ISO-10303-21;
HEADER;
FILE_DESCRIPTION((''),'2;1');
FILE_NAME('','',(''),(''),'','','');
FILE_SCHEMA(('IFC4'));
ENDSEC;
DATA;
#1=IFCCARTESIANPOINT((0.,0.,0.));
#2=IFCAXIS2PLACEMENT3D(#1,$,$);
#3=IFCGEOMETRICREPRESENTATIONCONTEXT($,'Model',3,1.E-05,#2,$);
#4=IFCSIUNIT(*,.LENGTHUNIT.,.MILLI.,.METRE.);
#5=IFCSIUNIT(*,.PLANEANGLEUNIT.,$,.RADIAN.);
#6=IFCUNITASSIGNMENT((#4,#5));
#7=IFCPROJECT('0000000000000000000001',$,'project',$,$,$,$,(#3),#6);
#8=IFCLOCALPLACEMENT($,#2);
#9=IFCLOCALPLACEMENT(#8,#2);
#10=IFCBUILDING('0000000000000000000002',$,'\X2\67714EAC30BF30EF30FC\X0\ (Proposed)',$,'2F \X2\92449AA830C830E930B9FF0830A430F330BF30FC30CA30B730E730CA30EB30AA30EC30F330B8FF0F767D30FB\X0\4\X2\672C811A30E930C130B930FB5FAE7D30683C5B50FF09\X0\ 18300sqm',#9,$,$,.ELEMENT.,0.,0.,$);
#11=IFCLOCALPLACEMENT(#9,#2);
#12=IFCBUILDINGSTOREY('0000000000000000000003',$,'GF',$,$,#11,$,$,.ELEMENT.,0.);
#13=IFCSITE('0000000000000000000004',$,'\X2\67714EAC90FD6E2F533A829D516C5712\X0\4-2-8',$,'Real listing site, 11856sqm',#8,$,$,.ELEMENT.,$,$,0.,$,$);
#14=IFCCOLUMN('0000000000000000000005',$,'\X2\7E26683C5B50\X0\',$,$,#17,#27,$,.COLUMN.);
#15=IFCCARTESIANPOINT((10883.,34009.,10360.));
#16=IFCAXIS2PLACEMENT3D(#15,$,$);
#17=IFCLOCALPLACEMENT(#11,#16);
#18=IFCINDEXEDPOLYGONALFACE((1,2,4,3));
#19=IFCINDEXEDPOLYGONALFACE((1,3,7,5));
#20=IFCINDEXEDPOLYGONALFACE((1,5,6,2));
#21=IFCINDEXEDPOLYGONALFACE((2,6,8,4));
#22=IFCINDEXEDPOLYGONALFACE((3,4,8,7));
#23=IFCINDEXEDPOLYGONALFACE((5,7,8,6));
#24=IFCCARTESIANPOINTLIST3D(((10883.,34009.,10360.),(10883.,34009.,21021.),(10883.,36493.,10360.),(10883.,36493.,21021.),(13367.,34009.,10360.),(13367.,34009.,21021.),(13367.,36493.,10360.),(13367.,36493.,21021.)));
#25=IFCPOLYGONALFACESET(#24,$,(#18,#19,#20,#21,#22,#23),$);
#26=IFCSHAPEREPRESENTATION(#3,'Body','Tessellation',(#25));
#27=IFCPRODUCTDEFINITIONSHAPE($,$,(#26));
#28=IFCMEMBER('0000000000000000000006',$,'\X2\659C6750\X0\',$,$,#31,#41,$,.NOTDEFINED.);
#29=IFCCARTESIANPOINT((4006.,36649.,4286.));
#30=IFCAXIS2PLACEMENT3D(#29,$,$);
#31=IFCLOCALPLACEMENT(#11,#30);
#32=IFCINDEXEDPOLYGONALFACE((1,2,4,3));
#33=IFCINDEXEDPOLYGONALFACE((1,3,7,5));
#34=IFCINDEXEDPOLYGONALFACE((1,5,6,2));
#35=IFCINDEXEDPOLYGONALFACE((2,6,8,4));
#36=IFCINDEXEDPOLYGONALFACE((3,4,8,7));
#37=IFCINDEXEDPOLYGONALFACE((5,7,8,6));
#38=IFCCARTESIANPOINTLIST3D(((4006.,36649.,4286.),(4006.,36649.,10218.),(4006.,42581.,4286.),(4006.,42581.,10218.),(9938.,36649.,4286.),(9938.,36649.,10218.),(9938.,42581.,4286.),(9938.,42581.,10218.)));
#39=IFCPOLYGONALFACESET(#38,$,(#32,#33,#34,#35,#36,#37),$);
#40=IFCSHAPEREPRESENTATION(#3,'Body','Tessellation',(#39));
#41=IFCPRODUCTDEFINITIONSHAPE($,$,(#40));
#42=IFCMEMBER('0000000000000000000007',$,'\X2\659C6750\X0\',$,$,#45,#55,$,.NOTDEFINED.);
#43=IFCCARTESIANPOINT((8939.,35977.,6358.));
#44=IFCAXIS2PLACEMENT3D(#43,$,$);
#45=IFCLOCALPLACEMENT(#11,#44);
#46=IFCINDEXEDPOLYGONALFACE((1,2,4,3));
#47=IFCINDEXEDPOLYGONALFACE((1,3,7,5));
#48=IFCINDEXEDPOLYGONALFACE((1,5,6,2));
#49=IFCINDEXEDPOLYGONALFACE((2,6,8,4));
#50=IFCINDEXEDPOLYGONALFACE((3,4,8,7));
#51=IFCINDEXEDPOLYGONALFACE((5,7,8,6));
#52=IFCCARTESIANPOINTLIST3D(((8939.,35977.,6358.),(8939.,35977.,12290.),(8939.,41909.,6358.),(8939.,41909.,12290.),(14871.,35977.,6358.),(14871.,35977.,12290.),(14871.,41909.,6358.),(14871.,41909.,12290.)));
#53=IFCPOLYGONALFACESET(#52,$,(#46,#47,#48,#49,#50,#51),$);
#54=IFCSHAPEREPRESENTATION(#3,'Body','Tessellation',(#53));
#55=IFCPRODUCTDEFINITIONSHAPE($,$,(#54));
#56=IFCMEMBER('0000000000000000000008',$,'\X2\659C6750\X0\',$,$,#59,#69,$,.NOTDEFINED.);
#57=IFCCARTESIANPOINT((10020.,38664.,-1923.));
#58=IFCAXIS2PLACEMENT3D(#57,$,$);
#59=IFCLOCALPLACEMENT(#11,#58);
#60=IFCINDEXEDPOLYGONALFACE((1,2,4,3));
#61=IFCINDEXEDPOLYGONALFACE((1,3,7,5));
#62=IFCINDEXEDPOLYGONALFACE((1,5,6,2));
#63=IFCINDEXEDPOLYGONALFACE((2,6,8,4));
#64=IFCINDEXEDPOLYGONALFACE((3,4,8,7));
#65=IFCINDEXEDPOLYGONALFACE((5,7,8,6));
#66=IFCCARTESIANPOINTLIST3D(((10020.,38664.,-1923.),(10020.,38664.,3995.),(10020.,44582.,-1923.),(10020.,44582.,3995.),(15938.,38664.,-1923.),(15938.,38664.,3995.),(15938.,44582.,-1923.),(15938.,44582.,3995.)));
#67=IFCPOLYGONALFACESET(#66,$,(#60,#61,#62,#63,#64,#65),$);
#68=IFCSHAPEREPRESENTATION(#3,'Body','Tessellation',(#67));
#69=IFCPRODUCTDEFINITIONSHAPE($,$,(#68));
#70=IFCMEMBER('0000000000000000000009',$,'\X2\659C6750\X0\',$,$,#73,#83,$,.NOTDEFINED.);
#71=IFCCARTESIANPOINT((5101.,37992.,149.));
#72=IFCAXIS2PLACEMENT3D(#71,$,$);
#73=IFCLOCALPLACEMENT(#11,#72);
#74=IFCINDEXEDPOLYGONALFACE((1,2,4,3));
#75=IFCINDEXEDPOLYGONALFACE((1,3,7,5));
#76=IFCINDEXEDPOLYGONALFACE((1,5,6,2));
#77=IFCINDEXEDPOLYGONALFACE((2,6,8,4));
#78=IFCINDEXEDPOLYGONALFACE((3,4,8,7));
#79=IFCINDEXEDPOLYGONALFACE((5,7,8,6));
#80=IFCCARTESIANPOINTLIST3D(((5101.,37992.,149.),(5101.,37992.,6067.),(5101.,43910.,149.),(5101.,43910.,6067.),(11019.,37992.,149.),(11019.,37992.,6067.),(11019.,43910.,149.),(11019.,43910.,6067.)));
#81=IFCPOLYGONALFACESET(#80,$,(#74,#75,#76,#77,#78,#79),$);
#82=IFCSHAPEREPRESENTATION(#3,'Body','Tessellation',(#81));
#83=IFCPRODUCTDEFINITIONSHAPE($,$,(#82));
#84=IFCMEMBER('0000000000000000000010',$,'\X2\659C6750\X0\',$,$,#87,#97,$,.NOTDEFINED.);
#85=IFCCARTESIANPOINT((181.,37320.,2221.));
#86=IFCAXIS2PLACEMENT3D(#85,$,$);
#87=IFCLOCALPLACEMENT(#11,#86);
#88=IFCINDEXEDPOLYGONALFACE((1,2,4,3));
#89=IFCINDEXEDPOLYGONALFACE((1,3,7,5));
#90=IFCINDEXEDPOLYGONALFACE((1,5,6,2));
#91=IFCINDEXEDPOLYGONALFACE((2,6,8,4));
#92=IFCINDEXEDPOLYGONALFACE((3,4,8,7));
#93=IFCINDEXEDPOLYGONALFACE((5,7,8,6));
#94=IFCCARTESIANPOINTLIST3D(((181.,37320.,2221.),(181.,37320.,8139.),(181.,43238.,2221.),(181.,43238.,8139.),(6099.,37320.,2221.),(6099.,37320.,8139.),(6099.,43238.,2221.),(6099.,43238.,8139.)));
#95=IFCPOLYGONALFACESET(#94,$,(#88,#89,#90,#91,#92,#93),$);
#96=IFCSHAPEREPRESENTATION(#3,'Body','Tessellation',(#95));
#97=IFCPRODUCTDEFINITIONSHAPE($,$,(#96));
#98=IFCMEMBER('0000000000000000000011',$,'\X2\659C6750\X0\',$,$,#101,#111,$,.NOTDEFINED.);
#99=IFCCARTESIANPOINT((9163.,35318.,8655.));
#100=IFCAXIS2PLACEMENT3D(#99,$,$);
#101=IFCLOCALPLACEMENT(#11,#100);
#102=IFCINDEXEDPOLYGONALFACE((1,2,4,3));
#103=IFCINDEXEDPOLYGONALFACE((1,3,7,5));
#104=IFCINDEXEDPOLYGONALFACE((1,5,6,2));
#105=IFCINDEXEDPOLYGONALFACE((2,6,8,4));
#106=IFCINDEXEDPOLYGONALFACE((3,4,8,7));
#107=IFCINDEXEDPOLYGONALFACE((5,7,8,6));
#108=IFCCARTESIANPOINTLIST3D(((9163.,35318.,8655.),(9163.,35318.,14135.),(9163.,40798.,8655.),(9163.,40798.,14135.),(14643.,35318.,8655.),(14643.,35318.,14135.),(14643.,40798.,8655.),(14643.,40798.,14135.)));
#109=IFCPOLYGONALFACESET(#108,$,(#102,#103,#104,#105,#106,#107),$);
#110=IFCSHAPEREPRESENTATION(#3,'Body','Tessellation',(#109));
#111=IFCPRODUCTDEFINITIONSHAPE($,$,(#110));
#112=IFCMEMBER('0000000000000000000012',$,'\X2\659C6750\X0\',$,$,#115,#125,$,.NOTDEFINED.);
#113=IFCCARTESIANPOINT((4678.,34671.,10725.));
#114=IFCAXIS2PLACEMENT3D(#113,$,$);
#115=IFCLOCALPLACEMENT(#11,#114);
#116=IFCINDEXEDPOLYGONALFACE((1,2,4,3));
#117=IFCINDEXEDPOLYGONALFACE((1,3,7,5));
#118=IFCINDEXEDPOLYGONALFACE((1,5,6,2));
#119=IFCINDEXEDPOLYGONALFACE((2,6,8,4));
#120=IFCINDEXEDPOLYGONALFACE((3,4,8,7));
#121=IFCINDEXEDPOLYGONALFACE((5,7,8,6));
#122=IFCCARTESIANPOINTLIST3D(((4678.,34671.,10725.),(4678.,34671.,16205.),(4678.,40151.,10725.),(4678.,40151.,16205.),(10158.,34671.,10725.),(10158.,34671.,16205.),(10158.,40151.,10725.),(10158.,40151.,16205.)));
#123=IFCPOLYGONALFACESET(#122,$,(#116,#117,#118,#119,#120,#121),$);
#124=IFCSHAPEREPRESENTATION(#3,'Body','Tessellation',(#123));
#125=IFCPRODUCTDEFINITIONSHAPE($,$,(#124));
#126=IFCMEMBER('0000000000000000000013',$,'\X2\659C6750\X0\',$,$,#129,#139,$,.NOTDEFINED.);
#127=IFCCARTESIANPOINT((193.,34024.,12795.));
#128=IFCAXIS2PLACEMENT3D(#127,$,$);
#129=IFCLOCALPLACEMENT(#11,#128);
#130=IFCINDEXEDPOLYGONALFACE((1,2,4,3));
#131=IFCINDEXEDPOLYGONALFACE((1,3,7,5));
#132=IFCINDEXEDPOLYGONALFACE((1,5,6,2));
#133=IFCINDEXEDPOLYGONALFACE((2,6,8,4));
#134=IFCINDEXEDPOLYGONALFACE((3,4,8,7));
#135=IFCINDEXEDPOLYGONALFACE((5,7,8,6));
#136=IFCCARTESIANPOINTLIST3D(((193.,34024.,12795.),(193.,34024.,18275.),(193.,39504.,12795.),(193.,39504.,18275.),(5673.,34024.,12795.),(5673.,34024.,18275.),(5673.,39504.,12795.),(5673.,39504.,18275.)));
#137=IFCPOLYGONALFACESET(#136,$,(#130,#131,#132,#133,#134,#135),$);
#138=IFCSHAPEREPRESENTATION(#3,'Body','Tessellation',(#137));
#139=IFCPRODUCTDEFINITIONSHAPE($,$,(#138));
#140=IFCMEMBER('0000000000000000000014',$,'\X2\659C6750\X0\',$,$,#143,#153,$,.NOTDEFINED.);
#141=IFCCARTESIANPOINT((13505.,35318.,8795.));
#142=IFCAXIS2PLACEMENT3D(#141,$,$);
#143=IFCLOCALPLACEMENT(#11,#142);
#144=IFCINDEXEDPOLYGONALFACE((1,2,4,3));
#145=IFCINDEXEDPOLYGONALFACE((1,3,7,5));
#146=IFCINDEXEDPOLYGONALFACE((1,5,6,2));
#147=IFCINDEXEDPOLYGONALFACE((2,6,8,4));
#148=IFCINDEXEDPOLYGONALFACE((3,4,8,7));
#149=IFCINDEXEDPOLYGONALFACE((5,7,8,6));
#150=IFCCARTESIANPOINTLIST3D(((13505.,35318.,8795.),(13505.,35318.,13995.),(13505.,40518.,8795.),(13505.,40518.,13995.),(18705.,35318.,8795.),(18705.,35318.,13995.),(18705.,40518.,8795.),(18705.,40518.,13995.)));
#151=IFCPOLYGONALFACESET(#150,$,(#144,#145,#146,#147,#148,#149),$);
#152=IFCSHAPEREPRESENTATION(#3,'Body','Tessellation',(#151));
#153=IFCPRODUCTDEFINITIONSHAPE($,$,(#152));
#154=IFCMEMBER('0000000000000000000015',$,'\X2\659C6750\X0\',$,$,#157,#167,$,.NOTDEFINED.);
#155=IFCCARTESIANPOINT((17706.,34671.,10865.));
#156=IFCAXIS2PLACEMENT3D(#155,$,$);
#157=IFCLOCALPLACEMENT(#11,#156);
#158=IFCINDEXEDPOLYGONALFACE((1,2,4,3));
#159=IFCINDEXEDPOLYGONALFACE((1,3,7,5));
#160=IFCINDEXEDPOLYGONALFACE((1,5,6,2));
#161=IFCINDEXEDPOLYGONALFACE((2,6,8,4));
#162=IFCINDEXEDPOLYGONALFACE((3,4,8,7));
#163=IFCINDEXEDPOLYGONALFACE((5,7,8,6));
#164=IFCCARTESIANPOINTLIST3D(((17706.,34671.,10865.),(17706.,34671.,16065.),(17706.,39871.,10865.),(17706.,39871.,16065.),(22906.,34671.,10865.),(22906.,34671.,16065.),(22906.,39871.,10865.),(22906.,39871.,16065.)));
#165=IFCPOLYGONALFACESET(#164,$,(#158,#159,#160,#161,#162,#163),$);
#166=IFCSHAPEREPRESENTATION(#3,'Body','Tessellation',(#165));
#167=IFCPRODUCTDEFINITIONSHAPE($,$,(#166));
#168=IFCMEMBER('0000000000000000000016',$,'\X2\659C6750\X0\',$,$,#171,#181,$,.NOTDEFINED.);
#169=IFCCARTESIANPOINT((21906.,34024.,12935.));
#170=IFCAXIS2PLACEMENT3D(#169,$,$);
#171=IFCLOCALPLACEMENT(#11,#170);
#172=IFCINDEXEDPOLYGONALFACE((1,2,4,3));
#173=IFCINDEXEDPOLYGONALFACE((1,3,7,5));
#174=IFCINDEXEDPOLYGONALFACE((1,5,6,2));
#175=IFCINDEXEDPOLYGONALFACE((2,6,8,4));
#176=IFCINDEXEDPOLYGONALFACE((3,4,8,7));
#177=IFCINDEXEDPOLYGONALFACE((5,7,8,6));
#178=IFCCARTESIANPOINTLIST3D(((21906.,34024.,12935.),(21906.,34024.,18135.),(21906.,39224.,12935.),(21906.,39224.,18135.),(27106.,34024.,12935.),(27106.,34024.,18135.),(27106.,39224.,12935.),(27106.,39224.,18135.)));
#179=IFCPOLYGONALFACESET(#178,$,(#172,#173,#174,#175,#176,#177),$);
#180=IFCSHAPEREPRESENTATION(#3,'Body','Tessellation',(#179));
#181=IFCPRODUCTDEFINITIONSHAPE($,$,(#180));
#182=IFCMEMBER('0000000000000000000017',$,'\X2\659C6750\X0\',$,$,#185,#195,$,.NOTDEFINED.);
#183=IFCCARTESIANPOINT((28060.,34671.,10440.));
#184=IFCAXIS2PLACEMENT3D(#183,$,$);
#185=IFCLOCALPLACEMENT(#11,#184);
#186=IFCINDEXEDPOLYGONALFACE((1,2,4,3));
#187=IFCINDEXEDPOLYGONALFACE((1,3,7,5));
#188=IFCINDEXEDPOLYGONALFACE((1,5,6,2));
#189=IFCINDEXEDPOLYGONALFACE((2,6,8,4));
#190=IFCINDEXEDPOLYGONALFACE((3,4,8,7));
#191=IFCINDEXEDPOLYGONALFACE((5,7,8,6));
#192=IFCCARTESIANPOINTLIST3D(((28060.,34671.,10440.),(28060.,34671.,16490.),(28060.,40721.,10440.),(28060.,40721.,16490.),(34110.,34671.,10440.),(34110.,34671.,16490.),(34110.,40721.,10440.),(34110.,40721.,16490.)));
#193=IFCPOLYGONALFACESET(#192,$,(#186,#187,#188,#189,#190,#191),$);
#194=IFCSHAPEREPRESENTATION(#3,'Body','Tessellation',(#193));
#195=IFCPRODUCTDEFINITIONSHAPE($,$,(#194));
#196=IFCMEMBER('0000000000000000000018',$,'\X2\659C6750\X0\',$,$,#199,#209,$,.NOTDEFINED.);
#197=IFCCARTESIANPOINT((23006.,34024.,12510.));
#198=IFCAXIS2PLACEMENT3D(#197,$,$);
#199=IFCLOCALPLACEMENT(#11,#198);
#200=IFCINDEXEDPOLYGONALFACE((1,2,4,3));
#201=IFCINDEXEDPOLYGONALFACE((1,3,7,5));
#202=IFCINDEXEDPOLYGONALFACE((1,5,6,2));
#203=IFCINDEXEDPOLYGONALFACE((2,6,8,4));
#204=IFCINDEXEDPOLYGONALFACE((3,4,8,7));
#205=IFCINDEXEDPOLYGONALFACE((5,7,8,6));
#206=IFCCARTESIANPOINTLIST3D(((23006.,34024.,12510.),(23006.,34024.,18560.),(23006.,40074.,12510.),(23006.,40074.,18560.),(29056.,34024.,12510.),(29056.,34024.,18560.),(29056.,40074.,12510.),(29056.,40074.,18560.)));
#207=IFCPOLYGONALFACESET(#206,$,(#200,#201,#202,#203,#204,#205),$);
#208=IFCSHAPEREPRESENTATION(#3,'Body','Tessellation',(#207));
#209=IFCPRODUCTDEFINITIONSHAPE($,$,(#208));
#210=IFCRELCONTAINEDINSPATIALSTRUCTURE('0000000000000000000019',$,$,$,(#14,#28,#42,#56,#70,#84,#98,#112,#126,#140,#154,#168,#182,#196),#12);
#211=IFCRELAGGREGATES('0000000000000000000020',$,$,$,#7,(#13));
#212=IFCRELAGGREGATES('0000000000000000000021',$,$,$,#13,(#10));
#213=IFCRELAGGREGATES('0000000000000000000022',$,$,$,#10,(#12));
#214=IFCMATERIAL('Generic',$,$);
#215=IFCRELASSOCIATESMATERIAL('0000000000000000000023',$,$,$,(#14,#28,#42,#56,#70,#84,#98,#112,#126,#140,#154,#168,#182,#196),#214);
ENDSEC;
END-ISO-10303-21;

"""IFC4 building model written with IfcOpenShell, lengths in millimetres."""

from ifc_helpers import new_model, si_unit, frame, frame_2d, origin, place, context, project, spatial, rectangle, extrude, material, element, save


model = new_model("IFC4")

# Units and contexts
model_context = context("Model", 3, precision=1e-05, world=origin())
ifc_project = project(units=[si_unit("LENGTHUNIT", "METRE", prefix="MILLI"), si_unit("PLANEANGLEUNIT", "RADIAN")], contexts=[model_context])

# Site, building, storey
site_placement = place(None, origin())
site = spatial("IfcSite", under=ifc_project, at=site_placement, Name="東京都港区芝公園4-2-8", ObjectType="Real listing site, 11856sqm", CompositionType="ELEMENT", RefElevation=0.0)
building_placement = place(site_placement, origin())
building = spatial("IfcBuilding", under=site, at=building_placement, Name="東京タワー (Proposed)", ObjectType="2F 鉄骨トラス（インターナショナルオレンジ／白・4本脚ラチス・微細格子） 18300sqm", CompositionType="ELEMENT", ElevationOfRefHeight=0.0, ElevationOfTerrain=0.0)
storey_placement = place(building_placement, origin())
storey = spatial("IfcBuildingStorey", under=building, at=storey_placement, Name="GF", CompositionType="ELEMENT", Elevation=0.0)

# Column
ifc_material = material(Name="Generic")
column_1_placement = place(storey_placement, frame((10883.0, 34009.0, 10360.0)))
element("IfcColumn", 1, at=column_1_placement, inside=storey, material=ifc_material, Name="縦格子", PredefinedType="COLUMN", context=model_context, shape_type="SweptSolid", body=[
    extrude(rectangle(XDim=2484.0, YDim=2484.0, at=frame_2d((1242.0, 1242.0))), frame((10883.0, 34009.0, 10360.0)), (0.0, 0.0, 1.0), 10661.0),
])

# Members
member_1_placement = place(storey_placement, frame((4006.0, 36649.0, 4286.0)))
element("IfcMember", 2, at=member_1_placement, inside=storey, material=ifc_material, Name="斜材", PredefinedType="NOTDEFINED", context=model_context, shape_type="SweptSolid", body=[
    extrude(rectangle(XDim=5932.0, YDim=5932.0, at=frame_2d((2966.0, 2966.0))), frame((4006.0, 36649.0, 4286.0)), (0.0, 0.0, 1.0), 5932.0),
])
member_2_placement = place(storey_placement, frame((8939.0, 35977.0, 6358.0)))
element("IfcMember", 3, at=member_2_placement, inside=storey, material=ifc_material, Name="斜材", PredefinedType="NOTDEFINED", context=model_context, shape_type="SweptSolid", body=[
    extrude(rectangle(XDim=5932.0, YDim=5932.0, at=frame_2d((2966.0, 2966.0))), frame((8939.0, 35977.0, 6358.0)), (0.0, 0.0, 1.0), 5932.0),
])
member_3_placement = place(storey_placement, frame((10020.0, 38664.0, -1923.0)))
element("IfcMember", 4, at=member_3_placement, inside=storey, material=ifc_material, Name="斜材", PredefinedType="NOTDEFINED", context=model_context, shape_type="SweptSolid", body=[
    extrude(rectangle(XDim=5918.0, YDim=5918.0, at=frame_2d((2959.0, 2959.0))), frame((10020.0, 38664.0, -1923.0)), (0.0, 0.0, 1.0), 5918.0),
])
member_4_placement = place(storey_placement, frame((5101.0, 37992.0, 149.0)))
element("IfcMember", 5, at=member_4_placement, inside=storey, material=ifc_material, Name="斜材", PredefinedType="NOTDEFINED", context=model_context, shape_type="SweptSolid", body=[
    extrude(rectangle(XDim=5918.0, YDim=5918.0, at=frame_2d((2959.0, 2959.0))), frame((5101.0, 37992.0, 149.0)), (0.0, 0.0, 1.0), 5918.0),
])
member_5_placement = place(storey_placement, frame((181.0, 37320.0, 2221.0)))
element("IfcMember", 6, at=member_5_placement, inside=storey, material=ifc_material, Name="斜材", PredefinedType="NOTDEFINED", context=model_context, shape_type="SweptSolid", body=[
    extrude(rectangle(XDim=5918.0, YDim=5918.0, at=frame_2d((2959.0, 2959.0))), frame((181.0, 37320.0, 2221.0)), (0.0, 0.0, 1.0), 5918.0),
])
member_6_placement = place(storey_placement, frame((9163.0, 35318.0, 8655.0)))
element("IfcMember", 7, at=member_6_placement, inside=storey, material=ifc_material, Name="斜材", PredefinedType="NOTDEFINED", context=model_context, shape_type="SweptSolid", body=[
    extrude(rectangle(XDim=5480.0, YDim=5480.0, at=frame_2d((2740.0, 2740.0))), frame((9163.0, 35318.0, 8655.0)), (0.0, 0.0, 1.0), 5480.0),
])
member_7_placement = place(storey_placement, frame((4678.0, 34671.0, 10725.0)))
element("IfcMember", 8, at=member_7_placement, inside=storey, material=ifc_material, Name="斜材", PredefinedType="NOTDEFINED", context=model_context, shape_type="SweptSolid", body=[
    extrude(rectangle(XDim=5480.0, YDim=5480.0, at=frame_2d((2740.0, 2740.0))), frame((4678.0, 34671.0, 10725.0)), (0.0, 0.0, 1.0), 5480.0),
])
member_8_placement = place(storey_placement, frame((193.0, 34024.0, 12795.0)))
element("IfcMember", 9, at=member_8_placement, inside=storey, material=ifc_material, Name="斜材", PredefinedType="NOTDEFINED", context=model_context, shape_type="SweptSolid", body=[
    extrude(rectangle(XDim=5480.0, YDim=5480.0, at=frame_2d((2740.0, 2740.0))), frame((193.0, 34024.0, 12795.0)), (0.0, 0.0, 1.0), 5480.0),
])
member_9_placement = place(storey_placement, frame((13505.0, 35318.0, 8795.0)))
element("IfcMember", 10, at=member_9_placement, inside=storey, material=ifc_material, Name="斜材", PredefinedType="NOTDEFINED", context=model_context, shape_type="SweptSolid", body=[
    extrude(rectangle(XDim=5200.0, YDim=5200.0, at=frame_2d((2600.0, 2600.0))), frame((13505.0, 35318.0, 8795.0)), (0.0, 0.0, 1.0), 5200.0),
])
member_10_placement = place(storey_placement, frame((17706.0, 34671.0, 10865.0)))
element("IfcMember", 11, at=member_10_placement, inside=storey, material=ifc_material, Name="斜材", PredefinedType="NOTDEFINED", context=model_context, shape_type="SweptSolid", body=[
    extrude(rectangle(XDim=5200.0, YDim=5200.0, at=frame_2d((2600.0, 2600.0))), frame((17706.0, 34671.0, 10865.0)), (0.0, 0.0, 1.0), 5200.0),
])
member_11_placement = place(storey_placement, frame((21906.0, 34024.0, 12935.0)))
element("IfcMember", 12, at=member_11_placement, inside=storey, material=ifc_material, Name="斜材", PredefinedType="NOTDEFINED", context=model_context, shape_type="SweptSolid", body=[
    extrude(rectangle(XDim=5200.0, YDim=5200.0, at=frame_2d((2600.0, 2600.0))), frame((21906.0, 34024.0, 12935.0)), (0.0, 0.0, 1.0), 5200.0),
])
member_12_placement = place(storey_placement, frame((28060.0, 34671.0, 10440.0)))
element("IfcMember", 13, at=member_12_placement, inside=storey, material=ifc_material, Name="斜材", PredefinedType="NOTDEFINED", context=model_context, shape_type="SweptSolid", body=[
    extrude(rectangle(XDim=6050.0, YDim=6050.0, at=frame_2d((3025.0, 3025.0))), frame((28060.0, 34671.0, 10440.0)), (0.0, 0.0, 1.0), 6050.0),
])
member_13_placement = place(storey_placement, frame((23006.0, 34024.0, 12510.0)))
element("IfcMember", 14, at=member_13_placement, inside=storey, material=ifc_material, Name="斜材", PredefinedType="NOTDEFINED", context=model_context, shape_type="SweptSolid", body=[
    extrude(rectangle(XDim=6050.0, YDim=6050.0, at=frame_2d((3025.0, 3025.0))), frame((23006.0, 34024.0, 12510.0)), (0.0, 0.0, 1.0), 6050.0),
])

save(model, "model.ifc")
